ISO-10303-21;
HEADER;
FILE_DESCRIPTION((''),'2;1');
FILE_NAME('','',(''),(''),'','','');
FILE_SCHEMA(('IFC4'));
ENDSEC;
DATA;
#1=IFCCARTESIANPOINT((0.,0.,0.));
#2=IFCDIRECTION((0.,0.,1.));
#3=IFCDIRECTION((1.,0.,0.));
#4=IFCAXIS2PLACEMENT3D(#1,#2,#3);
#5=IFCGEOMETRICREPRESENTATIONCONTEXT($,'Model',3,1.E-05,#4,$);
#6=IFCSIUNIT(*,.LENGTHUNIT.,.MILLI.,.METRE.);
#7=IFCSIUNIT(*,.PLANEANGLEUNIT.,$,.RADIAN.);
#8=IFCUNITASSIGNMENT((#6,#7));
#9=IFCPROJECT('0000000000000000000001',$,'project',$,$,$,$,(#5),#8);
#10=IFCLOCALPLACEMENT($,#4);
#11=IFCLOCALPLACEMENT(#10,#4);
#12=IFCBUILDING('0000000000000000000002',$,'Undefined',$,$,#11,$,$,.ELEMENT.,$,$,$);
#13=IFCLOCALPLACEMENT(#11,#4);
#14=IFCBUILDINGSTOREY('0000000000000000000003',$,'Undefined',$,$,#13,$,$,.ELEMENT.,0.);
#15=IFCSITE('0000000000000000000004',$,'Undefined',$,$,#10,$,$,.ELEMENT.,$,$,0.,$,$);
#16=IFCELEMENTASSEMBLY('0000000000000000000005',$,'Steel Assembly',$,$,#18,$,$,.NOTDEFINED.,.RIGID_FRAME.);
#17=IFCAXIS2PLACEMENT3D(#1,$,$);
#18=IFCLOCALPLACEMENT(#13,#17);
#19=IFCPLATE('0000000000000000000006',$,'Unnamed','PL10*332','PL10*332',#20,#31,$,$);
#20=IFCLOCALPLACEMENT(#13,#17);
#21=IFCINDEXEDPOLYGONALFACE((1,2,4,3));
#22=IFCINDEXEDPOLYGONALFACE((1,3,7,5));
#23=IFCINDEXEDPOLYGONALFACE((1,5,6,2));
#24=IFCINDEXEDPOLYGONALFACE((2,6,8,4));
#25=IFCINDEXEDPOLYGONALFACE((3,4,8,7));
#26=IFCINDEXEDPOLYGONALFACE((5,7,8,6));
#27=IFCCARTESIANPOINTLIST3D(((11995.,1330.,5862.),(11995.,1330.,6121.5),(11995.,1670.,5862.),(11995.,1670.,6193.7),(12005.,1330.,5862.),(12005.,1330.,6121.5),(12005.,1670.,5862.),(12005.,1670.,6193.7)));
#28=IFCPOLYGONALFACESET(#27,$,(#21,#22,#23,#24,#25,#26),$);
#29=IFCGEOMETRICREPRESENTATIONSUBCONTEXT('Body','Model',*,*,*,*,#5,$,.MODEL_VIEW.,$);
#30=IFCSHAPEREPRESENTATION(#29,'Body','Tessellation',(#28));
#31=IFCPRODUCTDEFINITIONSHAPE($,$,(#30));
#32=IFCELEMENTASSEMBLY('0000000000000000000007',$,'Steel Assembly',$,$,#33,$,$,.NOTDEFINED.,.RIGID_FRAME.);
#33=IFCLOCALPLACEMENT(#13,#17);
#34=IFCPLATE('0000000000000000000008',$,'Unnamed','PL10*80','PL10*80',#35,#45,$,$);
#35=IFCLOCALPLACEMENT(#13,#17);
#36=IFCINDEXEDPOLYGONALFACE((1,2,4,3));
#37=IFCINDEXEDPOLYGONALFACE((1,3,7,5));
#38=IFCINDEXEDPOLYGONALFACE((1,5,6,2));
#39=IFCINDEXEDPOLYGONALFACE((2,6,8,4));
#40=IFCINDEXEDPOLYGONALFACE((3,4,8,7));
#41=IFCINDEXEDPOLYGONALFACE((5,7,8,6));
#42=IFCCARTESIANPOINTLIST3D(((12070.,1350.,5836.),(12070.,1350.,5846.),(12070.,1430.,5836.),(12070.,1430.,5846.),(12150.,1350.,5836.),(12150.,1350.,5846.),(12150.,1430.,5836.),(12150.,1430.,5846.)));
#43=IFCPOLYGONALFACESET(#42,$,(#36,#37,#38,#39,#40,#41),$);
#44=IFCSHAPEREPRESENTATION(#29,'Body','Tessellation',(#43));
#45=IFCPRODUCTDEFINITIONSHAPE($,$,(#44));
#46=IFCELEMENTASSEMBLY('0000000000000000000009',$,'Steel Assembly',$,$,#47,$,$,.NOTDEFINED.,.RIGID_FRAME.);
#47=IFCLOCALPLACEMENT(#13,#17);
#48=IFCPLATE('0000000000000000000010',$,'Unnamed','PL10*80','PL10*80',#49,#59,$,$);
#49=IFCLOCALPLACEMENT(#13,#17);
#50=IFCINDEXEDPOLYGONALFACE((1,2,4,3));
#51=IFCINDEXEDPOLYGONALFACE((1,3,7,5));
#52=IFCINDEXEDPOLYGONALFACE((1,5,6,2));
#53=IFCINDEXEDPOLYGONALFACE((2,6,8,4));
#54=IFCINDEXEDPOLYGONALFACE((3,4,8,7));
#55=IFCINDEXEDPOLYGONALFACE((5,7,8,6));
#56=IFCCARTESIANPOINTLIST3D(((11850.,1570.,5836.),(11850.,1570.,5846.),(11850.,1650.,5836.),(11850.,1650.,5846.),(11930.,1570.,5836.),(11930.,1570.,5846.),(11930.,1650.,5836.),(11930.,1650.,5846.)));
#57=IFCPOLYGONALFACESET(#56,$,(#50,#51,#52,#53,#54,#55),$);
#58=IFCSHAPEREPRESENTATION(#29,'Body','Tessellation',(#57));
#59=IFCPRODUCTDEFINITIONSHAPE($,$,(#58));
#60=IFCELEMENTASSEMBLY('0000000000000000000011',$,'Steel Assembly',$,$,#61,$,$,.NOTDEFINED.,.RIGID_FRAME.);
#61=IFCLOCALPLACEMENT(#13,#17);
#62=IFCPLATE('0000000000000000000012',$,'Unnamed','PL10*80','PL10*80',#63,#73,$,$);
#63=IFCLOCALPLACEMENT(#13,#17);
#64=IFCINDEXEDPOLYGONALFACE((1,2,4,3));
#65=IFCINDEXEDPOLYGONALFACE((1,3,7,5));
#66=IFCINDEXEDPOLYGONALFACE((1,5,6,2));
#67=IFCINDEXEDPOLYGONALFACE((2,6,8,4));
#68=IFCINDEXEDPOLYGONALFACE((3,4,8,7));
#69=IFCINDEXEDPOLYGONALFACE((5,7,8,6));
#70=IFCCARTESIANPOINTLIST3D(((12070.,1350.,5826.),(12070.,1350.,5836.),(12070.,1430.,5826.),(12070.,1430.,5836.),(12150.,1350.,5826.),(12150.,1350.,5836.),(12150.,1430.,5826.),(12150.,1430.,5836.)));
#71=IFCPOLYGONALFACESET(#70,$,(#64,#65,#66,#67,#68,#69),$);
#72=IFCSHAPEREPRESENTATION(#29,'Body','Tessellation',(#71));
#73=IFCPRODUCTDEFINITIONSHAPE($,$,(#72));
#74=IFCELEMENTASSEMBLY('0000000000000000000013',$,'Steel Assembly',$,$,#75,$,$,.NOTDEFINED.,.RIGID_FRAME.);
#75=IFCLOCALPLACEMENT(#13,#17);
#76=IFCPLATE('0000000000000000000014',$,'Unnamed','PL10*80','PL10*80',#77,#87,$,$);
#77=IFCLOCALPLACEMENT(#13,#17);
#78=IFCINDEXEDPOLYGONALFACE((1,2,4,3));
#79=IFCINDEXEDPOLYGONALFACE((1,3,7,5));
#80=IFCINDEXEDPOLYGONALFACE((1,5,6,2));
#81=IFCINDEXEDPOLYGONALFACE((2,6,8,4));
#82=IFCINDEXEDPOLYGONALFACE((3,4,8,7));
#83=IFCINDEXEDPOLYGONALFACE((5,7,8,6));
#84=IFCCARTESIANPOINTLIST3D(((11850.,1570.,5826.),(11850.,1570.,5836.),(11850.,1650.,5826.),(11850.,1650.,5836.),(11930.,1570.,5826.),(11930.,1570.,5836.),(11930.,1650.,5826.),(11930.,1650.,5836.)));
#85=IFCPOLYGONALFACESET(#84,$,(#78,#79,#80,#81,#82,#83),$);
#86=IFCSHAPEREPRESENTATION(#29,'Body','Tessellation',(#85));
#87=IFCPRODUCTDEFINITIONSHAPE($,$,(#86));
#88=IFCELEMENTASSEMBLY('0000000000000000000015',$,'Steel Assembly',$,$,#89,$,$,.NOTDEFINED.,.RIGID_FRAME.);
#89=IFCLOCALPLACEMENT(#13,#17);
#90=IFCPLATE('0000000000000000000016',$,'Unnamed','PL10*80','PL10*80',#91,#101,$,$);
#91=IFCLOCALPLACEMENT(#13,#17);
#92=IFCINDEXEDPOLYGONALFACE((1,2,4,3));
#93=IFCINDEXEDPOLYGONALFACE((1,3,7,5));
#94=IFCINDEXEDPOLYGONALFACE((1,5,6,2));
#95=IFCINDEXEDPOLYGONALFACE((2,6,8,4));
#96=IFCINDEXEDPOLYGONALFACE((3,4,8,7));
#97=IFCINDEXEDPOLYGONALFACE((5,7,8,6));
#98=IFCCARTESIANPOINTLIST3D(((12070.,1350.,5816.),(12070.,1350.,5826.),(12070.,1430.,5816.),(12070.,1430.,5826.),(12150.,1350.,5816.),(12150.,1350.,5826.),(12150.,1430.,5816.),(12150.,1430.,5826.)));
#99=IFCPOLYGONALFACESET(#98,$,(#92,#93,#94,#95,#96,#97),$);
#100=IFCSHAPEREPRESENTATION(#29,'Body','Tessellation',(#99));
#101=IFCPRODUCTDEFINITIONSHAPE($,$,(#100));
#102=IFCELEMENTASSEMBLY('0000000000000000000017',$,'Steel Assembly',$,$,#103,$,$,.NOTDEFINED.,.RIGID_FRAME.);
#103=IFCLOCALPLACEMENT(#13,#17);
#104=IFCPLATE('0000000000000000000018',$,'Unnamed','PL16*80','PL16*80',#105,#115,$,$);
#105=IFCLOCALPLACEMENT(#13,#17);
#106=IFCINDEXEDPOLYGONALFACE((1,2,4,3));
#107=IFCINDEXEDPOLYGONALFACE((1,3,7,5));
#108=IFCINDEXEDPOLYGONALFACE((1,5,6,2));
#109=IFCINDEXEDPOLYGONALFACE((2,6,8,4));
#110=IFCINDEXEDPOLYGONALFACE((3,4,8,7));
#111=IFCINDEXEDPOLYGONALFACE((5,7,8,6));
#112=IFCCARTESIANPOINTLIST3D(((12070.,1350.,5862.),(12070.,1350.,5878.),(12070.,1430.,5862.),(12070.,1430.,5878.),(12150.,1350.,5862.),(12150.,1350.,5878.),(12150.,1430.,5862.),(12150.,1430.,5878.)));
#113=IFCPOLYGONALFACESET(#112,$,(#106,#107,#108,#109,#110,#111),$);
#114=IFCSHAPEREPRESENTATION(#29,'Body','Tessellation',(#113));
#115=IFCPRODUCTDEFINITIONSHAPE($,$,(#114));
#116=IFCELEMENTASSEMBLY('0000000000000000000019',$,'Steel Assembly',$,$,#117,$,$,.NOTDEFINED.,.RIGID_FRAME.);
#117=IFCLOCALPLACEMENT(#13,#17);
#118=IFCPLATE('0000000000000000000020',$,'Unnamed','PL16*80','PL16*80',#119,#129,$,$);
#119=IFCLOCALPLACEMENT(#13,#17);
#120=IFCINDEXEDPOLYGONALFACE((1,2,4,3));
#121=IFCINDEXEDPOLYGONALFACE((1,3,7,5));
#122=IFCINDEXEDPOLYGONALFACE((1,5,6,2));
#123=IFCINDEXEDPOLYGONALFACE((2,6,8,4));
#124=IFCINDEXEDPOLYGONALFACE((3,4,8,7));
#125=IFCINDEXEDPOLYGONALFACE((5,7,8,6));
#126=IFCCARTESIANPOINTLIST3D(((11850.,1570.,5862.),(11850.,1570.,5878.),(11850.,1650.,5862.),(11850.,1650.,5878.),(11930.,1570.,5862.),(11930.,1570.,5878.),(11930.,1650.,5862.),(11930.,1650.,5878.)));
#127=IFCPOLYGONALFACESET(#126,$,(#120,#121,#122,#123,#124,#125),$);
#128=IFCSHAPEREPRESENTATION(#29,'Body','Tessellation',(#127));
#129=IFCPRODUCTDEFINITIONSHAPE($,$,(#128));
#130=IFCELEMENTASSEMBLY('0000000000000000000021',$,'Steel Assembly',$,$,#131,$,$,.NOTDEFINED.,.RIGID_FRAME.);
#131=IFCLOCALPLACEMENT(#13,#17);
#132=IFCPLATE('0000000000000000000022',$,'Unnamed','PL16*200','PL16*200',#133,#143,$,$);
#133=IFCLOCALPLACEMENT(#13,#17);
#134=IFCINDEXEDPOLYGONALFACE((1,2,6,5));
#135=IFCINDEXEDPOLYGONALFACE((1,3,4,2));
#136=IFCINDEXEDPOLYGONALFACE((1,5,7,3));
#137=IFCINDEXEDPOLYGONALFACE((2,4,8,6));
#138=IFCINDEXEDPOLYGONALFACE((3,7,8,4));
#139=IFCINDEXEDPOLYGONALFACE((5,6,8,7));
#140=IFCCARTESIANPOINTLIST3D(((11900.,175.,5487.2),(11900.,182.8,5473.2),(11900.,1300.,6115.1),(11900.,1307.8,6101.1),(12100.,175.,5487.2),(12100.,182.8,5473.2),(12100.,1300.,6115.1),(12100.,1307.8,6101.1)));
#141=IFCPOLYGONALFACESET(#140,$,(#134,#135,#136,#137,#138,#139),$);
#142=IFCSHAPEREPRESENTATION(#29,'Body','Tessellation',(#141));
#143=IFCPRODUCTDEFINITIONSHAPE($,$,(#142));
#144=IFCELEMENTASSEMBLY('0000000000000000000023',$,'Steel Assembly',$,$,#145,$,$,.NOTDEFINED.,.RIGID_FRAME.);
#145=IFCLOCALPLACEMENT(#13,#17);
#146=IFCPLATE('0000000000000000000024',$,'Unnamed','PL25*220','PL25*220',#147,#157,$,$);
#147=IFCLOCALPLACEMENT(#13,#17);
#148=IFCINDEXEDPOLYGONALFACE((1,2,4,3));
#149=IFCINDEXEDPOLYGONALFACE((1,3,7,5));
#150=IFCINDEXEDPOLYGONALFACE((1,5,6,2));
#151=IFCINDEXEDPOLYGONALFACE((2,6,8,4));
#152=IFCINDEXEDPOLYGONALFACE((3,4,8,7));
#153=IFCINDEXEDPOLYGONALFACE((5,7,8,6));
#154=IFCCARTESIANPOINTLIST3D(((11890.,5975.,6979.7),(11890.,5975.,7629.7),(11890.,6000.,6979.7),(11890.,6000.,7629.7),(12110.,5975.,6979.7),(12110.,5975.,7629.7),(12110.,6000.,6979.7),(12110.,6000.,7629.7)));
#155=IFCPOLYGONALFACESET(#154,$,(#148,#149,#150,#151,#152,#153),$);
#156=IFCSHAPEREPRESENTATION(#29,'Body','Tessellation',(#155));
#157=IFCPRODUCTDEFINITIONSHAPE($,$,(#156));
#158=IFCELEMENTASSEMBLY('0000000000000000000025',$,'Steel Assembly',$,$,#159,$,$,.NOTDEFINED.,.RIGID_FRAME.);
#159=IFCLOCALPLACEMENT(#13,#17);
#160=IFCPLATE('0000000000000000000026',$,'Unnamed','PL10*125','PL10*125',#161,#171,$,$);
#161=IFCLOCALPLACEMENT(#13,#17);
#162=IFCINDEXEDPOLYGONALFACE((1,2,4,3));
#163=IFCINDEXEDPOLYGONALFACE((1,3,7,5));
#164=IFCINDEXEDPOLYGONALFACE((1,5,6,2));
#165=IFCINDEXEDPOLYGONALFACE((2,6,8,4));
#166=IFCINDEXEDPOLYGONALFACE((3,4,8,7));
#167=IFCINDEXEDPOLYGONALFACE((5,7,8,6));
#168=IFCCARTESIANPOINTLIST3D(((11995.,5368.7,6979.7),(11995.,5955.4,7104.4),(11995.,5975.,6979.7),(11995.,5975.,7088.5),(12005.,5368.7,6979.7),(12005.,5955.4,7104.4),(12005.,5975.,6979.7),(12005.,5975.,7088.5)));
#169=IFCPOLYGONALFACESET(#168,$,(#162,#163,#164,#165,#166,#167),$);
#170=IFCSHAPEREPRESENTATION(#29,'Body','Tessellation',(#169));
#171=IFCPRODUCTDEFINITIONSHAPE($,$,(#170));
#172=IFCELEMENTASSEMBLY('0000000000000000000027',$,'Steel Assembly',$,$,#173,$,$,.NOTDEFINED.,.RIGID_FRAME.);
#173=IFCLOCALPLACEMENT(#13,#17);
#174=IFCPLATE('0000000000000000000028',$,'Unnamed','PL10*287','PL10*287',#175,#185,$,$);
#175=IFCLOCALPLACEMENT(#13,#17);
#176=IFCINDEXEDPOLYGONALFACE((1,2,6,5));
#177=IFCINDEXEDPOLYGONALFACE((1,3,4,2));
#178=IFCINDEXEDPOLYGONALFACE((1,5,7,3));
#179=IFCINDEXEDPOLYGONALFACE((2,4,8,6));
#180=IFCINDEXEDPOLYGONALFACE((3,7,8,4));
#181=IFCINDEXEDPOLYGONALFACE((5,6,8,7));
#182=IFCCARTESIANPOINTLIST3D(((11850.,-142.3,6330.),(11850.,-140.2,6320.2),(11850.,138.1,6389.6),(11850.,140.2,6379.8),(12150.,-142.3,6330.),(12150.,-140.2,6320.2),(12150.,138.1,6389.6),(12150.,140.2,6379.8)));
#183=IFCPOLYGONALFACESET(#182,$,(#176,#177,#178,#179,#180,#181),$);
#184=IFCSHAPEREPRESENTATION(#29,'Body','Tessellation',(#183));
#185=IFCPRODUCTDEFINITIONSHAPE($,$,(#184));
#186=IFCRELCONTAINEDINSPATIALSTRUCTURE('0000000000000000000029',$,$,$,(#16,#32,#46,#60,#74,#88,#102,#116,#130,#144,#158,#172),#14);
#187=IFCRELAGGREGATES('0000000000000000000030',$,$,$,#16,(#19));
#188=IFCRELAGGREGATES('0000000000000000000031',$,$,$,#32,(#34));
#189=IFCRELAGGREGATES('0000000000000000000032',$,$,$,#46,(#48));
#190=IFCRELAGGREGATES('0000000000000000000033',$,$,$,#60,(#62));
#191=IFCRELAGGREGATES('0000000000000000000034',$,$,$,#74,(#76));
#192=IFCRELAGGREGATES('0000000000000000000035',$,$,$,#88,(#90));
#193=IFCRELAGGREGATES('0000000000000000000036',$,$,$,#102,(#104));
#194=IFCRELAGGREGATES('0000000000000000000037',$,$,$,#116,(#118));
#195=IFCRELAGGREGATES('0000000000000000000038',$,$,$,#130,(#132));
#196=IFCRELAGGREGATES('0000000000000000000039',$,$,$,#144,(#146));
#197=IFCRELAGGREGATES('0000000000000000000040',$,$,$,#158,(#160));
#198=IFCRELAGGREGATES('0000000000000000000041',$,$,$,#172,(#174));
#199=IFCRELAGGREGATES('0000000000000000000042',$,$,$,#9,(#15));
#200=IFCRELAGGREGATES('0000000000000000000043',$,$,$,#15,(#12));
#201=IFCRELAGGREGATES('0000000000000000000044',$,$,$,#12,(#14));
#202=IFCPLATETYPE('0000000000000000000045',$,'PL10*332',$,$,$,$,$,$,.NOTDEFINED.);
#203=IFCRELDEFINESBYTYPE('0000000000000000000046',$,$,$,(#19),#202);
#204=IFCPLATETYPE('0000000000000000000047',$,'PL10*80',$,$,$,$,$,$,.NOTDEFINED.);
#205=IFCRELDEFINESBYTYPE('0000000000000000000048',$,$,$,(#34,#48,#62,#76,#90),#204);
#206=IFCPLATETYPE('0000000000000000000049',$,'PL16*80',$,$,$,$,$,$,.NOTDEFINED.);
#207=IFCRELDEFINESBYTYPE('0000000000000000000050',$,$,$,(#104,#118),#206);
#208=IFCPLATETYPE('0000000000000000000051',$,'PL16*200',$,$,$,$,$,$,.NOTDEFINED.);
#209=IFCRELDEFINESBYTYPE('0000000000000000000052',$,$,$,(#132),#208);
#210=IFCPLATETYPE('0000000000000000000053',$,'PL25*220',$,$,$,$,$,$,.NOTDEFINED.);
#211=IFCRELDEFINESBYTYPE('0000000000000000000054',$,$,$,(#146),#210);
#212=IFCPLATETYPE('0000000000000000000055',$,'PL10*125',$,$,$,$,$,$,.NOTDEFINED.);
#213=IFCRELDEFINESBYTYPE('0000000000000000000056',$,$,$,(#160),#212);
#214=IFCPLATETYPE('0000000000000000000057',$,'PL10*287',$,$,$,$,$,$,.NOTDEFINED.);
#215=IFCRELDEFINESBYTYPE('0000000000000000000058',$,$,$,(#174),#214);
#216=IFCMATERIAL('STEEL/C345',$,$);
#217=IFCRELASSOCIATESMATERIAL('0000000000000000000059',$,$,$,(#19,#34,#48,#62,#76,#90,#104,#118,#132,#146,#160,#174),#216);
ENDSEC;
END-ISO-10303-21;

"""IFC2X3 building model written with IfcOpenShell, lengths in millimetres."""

from ifc_helpers import new_model, si_unit, frame, origin_with_axes, place, context, subcontext, project, spatial, polyline, outline, extrude, material, type_object, element, aggregate, save


model = new_model("IFC2X3")

# Units and contexts
model_context = context("Model", 3, precision=1e-05, world=origin_with_axes())
body_context = subcontext(model_context, "Body", "Model", "MODEL_VIEW")
ifc_project = project(units=[si_unit("LENGTHUNIT", "METRE", prefix="MILLI"), si_unit("PLANEANGLEUNIT", "RADIAN")], contexts=[model_context])

# Site, building, storey
site_placement = place(None, origin_with_axes())
site = spatial("IfcSite", under=ifc_project, at=site_placement, Name="Undefined", CompositionType="ELEMENT", RefElevation=0.0)
building_placement = place(site_placement, origin_with_axes())
building = spatial("IfcBuilding", under=site, at=building_placement, Name="Undefined", CompositionType="ELEMENT")
storey_placement = place(building_placement, origin_with_axes())
storey = spatial("IfcBuildingStorey", under=building, at=storey_placement, Name="Undefined", CompositionType="ELEMENT", Elevation=0.0)

# Shared definitions
ifc_material = material(Name="STEEL/C345")

# Element assemblies, plates
assembly_1_placement = place(storey_placement, origin_with_axes())
assembly_1 = element("IfcElementAssembly", 1, at=assembly_1_placement, inside=storey, Name="Steel Assembly", AssemblyPlace="NOTDEFINED", PredefinedType="RIGID_FRAME")
plate_type_1 = type_object("IfcPlateType", Name="PL10*332", PredefinedType="NOTDEFINED")
plate_1_placement = place(assembly_1_placement, frame((12000.0, 1670.0, 5862.0), z_axis=(-1.0, 0.0, 0.0), x_axis=(0.0, -1.0, 0.0)))
plate_1 = element("IfcPlate", 2, at=plate_1_placement, type_object=plate_type_1, material=ifc_material, Name="Unnamed", Description="PL10*332", ObjectType="PL10*332", context=body_context, shape_type="SweptSolid", body=[
    extrude(outline(polyline([(0.0, 0.0), (340.0, 0.0), (340.0, 259.5), (0.0, 331.7), (0.0, 0.0)])), frame((0.0, 0.0, -5.0), z_axis=(0.0, 0.0, 1.0), x_axis=(1.0, 0.0, 0.0)), (0.0, 0.0, 1.0), 10.0),
])
aggregate(assembly_1, [plate_1])
assembly_2_placement = place(storey_placement, origin_with_axes())
assembly_2 = element("IfcElementAssembly", 3, at=assembly_2_placement, inside=storey, Name="Steel Assembly", AssemblyPlace="NOTDEFINED", PredefinedType="RIGID_FRAME")
plate_type_2 = type_object("IfcPlateType", Name="PL10*80", PredefinedType="NOTDEFINED")
plate_2_placement = place(assembly_2_placement, frame((12150.0, 1350.0, 5841.0), z_axis=(0.0, 0.0, 1.0), x_axis=(0.0, 1.0, 0.0)))
plate_2 = element("IfcPlate", 4, at=plate_2_placement, type_object=plate_type_2, material=ifc_material, Name="Unnamed", Description="PL10*80", ObjectType="PL10*80", context=body_context, shape_type="SweptSolid", body=[
    extrude(outline(polyline([(0.0, 0.0), (80.0, 0.0), (80.0, 80.0), (0.0, 80.0), (0.0, 0.0)])), frame((0.0, 0.0, -5.0), z_axis=(0.0, 0.0, 1.0), x_axis=(1.0, 0.0, 0.0)), (0.0, 0.0, 1.0), 10.0),
])
aggregate(assembly_2, [plate_2])
assembly_3_placement = place(storey_placement, origin_with_axes())
assembly_3 = element("IfcElementAssembly", 5, at=assembly_3_placement, inside=storey, Name="Steel Assembly", AssemblyPlace="NOTDEFINED", PredefinedType="RIGID_FRAME")
plate_3_placement = place(assembly_3_placement, frame((11850.0, 1650.0, 5841.0), z_axis=(0.0, 0.0, 1.0), x_axis=(0.0, -1.0, 0.0)))
plate_3 = element("IfcPlate", 6, at=plate_3_placement, type_object=plate_type_2, material=ifc_material, Name="Unnamed", Description="PL10*80", ObjectType="PL10*80", context=body_context, shape_type="SweptSolid", body=[
    extrude(outline(polyline([(0.0, 0.0), (80.0, 0.0), (80.0, 80.0), (0.0, 80.0), (0.0, 0.0)])), frame((0.0, 0.0, -5.0), z_axis=(0.0, 0.0, 1.0), x_axis=(1.0, 0.0, 0.0)), (0.0, 0.0, 1.0), 10.0),
])
aggregate(assembly_3, [plate_3])
assembly_4_placement = place(storey_placement, origin_with_axes())
assembly_4 = element("IfcElementAssembly", 7, at=assembly_4_placement, inside=storey, Name="Steel Assembly", AssemblyPlace="NOTDEFINED", PredefinedType="RIGID_FRAME")
plate_4_placement = place(assembly_4_placement, frame((12150.0, 1350.0, 5831.0), z_axis=(0.0, 0.0, 1.0), x_axis=(0.0, 1.0, 0.0)))
plate_4 = element("IfcPlate", 8, at=plate_4_placement, type_object=plate_type_2, material=ifc_material, Name="Unnamed", Description="PL10*80", ObjectType="PL10*80", context=body_context, shape_type="SweptSolid", body=[
    extrude(outline(polyline([(0.0, 0.0), (80.0, 0.0), (80.0, 80.0), (0.0, 80.0), (0.0, 0.0)])), frame((0.0, 0.0, -5.0), z_axis=(0.0, 0.0, 1.0), x_axis=(1.0, 0.0, 0.0)), (0.0, 0.0, 1.0), 10.0),
])
aggregate(assembly_4, [plate_4])
assembly_5_placement = place(storey_placement, origin_with_axes())
assembly_5 = element("IfcElementAssembly", 9, at=assembly_5_placement, inside=storey, Name="Steel Assembly", AssemblyPlace="NOTDEFINED", PredefinedType="RIGID_FRAME")
plate_5_placement = place(assembly_5_placement, frame((11850.0, 1650.0, 5831.0), z_axis=(0.0, 0.0, 1.0), x_axis=(0.0, -1.0, 0.0)))
plate_5 = element("IfcPlate", 10, at=plate_5_placement, type_object=plate_type_2, material=ifc_material, Name="Unnamed", Description="PL10*80", ObjectType="PL10*80", context=body_context, shape_type="SweptSolid", body=[
    extrude(outline(polyline([(0.0, 0.0), (80.0, 0.0), (80.0, 80.0), (0.0, 80.0), (0.0, 0.0)])), frame((0.0, 0.0, -5.0), z_axis=(0.0, 0.0, 1.0), x_axis=(1.0, 0.0, 0.0)), (0.0, 0.0, 1.0), 10.0),
])
aggregate(assembly_5, [plate_5])
assembly_6_placement = place(storey_placement, origin_with_axes())
assembly_6 = element("IfcElementAssembly", 11, at=assembly_6_placement, inside=storey, Name="Steel Assembly", AssemblyPlace="NOTDEFINED", PredefinedType="RIGID_FRAME")
plate_6_placement = place(assembly_6_placement, frame((12150.0, 1350.0, 5821.0), z_axis=(0.0, 0.0, 1.0), x_axis=(0.0, 1.0, 0.0)))
plate_6 = element("IfcPlate", 12, at=plate_6_placement, type_object=plate_type_2, material=ifc_material, Name="Unnamed", Description="PL10*80", ObjectType="PL10*80", context=body_context, shape_type="SweptSolid", body=[
    extrude(outline(polyline([(0.0, 0.0), (80.0, 0.0), (80.0, 80.0), (0.0, 80.0), (0.0, 0.0)])), frame((0.0, 0.0, -5.0), z_axis=(0.0, 0.0, 1.0), x_axis=(1.0, 0.0, 0.0)), (0.0, 0.0, 1.0), 10.0),
])
aggregate(assembly_6, [plate_6])
assembly_7_placement = place(storey_placement, origin_with_axes())
assembly_7 = element("IfcElementAssembly", 13, at=assembly_7_placement, inside=storey, Name="Steel Assembly", AssemblyPlace="NOTDEFINED", PredefinedType="RIGID_FRAME")
plate_type_3 = type_object("IfcPlateType", Name="PL16*80", PredefinedType="NOTDEFINED")
plate_7_placement = place(assembly_7_placement, frame((12150.0, 1350.0, 5870.0), z_axis=(0.0, 0.0, 1.0), x_axis=(0.0, 1.0, 0.0)))
plate_7 = element("IfcPlate", 14, at=plate_7_placement, type_object=plate_type_3, material=ifc_material, Name="Unnamed", Description="PL16*80", ObjectType="PL16*80", context=body_context, shape_type="SweptSolid", body=[
    extrude(outline(polyline([(0.0, 0.0), (80.0, 0.0), (80.0, 80.0), (0.0, 80.0), (0.0, 0.0)])), frame((0.0, 0.0, -8.0), z_axis=(0.0, 0.0, 1.0), x_axis=(1.0, 0.0, 0.0)), (0.0, 0.0, 1.0), 16.0),
])
aggregate(assembly_7, [plate_7])
assembly_8_placement = place(storey_placement, origin_with_axes())
assembly_8 = element("IfcElementAssembly", 15, at=assembly_8_placement, inside=storey, Name="Steel Assembly", AssemblyPlace="NOTDEFINED", PredefinedType="RIGID_FRAME")
plate_8_placement = place(assembly_8_placement, frame((11850.0, 1650.0, 5870.0), z_axis=(0.0, 0.0, 1.0), x_axis=(0.0, -1.0, 0.0)))
plate_8 = element("IfcPlate", 16, at=plate_8_placement, type_object=plate_type_3, material=ifc_material, Name="Unnamed", Description="PL16*80", ObjectType="PL16*80", context=body_context, shape_type="SweptSolid", body=[
    extrude(outline(polyline([(0.0, 0.0), (80.0, 0.0), (80.0, 80.0), (0.0, 80.0), (0.0, 0.0)])), frame((0.0, 0.0, -8.0), z_axis=(0.0, 0.0, 1.0), x_axis=(1.0, 0.0, 0.0)), (0.0, 0.0, 1.0), 16.0),
])
aggregate(assembly_8, [plate_8])
assembly_9_placement = place(storey_placement, origin_with_axes())
assembly_9 = element("IfcElementAssembly", 17, at=assembly_9_placement, inside=storey, Name="Steel Assembly", AssemblyPlace="NOTDEFINED", PredefinedType="RIGID_FRAME")
plate_type_4 = type_object("IfcPlateType", Name="PL16*200", PredefinedType="NOTDEFINED")
plate_9_placement = place(assembly_9_placement, frame((12100.0, 178.9, 5480.2), z_axis=(0.0, 0.487361, -0.8732), x_axis=(-1.0, 0.0, 0.0)))
plate_9 = element("IfcPlate", 18, at=plate_9_placement, type_object=plate_type_4, material=ifc_material, Name="Unnamed", Description="PL16*200", ObjectType="PL16*200", context=body_context, shape_type="SweptSolid", body=[
    extrude(outline(polyline([(0.0, 0.0), (200.0, 0.0), (200.0, 1288.4), (0.0, 1288.4), (0.0, 0.0)])), frame((0.0, 0.0, -8.0), z_axis=(0.0, 0.0, 1.0), x_axis=(1.0, 0.0, 0.0)), (0.0, 0.0, 1.0), 16.0),
])
aggregate(assembly_9, [plate_9])
assembly_10_placement = place(storey_placement, origin_with_axes())
assembly_10 = element("IfcElementAssembly", 19, at=assembly_10_placement, inside=storey, Name="Steel Assembly", AssemblyPlace="NOTDEFINED", PredefinedType="RIGID_FRAME")
plate_type_5 = type_object("IfcPlateType", Name="PL25*220", PredefinedType="NOTDEFINED")
plate_10_placement = place(assembly_10_placement, frame((11890.0, 5987.5, 6979.7), z_axis=(0.0, 1.0, 0.0), x_axis=(0.0, 0.0, 1.0)))
plate_10 = element("IfcPlate", 20, at=plate_10_placement, type_object=plate_type_5, material=ifc_material, Name="Unnamed", Description="PL25*220", ObjectType="PL25*220", context=body_context, shape_type="SweptSolid", body=[
    extrude(outline(polyline([(0.0, 0.0), (650.0, 0.0), (650.0, 220.0), (0.0, 220.0), (0.0, 0.0)])), frame((0.0, 0.0, -12.5), z_axis=(0.0, 0.0, 1.0), x_axis=(1.0, 0.0, 0.0)), (0.0, 0.0, 1.0), 25.0),
])
aggregate(assembly_10, [plate_10])
assembly_11_placement = place(storey_placement, origin_with_axes())
assembly_11 = element("IfcElementAssembly", 21, at=assembly_11_placement, inside=storey, Name="Steel Assembly", AssemblyPlace="NOTDEFINED", PredefinedType="RIGID_FRAME")
plate_type_6 = type_object("IfcPlateType", Name="PL10*125", PredefinedType="NOTDEFINED")
plate_11_placement = place(assembly_11_placement, frame((12000.0, 5368.7, 6979.7), z_axis=(1.0, 0.0, 0.0), x_axis=(0.0, 1.0, 0.0)))
plate_11 = element("IfcPlate", 22, at=plate_11_placement, type_object=plate_type_6, material=ifc_material, Name="Unnamed", Description="PL10*125", ObjectType="PL10*125", context=body_context, shape_type="SweptSolid", body=[
    extrude(outline(polyline([(0.0, 0.0), (606.3, 0.0), (606.3, 108.8), (586.7, 124.7), (0.0, 0.0)])), frame((0.0, 0.0, -5.0), z_axis=(0.0, 0.0, 1.0), x_axis=(1.0, 0.0, 0.0)), (0.0, 0.0, 1.0), 10.0),
])
aggregate(assembly_11, [plate_11])
assembly_12_placement = place(storey_placement, origin_with_axes())
assembly_12 = element("IfcElementAssembly", 23, at=assembly_12_placement, inside=storey, Name="Steel Assembly", AssemblyPlace="NOTDEFINED", PredefinedType="RIGID_FRAME")
plate_type_7 = type_object("IfcPlateType", Name="PL10*287", PredefinedType="NOTDEFINED")
plate_12_placement = place(assembly_12_placement, frame((12150.0, -141.3, 6325.1), z_axis=(0.0, 0.207859, -0.978159), x_axis=(-1.0, 0.0, 0.0)))
plate_12 = element("IfcPlate", 24, at=plate_12_placement, type_object=plate_type_7, material=ifc_material, Name="Unnamed", Description="PL10*287", ObjectType="PL10*287", context=body_context, shape_type="SweptSolid", body=[
    extrude(outline(polyline([(0.0, 0.0), (300.0, 0.0), (300.0, 286.7), (0.0, 286.7), (0.0, 0.0)])), frame((0.0, 0.0, -5.0), z_axis=(0.0, 0.0, 1.0), x_axis=(1.0, 0.0, 0.0)), (0.0, 0.0, 1.0), 10.0),
])
aggregate(assembly_12, [plate_12])

save(model, "model.ifc")
